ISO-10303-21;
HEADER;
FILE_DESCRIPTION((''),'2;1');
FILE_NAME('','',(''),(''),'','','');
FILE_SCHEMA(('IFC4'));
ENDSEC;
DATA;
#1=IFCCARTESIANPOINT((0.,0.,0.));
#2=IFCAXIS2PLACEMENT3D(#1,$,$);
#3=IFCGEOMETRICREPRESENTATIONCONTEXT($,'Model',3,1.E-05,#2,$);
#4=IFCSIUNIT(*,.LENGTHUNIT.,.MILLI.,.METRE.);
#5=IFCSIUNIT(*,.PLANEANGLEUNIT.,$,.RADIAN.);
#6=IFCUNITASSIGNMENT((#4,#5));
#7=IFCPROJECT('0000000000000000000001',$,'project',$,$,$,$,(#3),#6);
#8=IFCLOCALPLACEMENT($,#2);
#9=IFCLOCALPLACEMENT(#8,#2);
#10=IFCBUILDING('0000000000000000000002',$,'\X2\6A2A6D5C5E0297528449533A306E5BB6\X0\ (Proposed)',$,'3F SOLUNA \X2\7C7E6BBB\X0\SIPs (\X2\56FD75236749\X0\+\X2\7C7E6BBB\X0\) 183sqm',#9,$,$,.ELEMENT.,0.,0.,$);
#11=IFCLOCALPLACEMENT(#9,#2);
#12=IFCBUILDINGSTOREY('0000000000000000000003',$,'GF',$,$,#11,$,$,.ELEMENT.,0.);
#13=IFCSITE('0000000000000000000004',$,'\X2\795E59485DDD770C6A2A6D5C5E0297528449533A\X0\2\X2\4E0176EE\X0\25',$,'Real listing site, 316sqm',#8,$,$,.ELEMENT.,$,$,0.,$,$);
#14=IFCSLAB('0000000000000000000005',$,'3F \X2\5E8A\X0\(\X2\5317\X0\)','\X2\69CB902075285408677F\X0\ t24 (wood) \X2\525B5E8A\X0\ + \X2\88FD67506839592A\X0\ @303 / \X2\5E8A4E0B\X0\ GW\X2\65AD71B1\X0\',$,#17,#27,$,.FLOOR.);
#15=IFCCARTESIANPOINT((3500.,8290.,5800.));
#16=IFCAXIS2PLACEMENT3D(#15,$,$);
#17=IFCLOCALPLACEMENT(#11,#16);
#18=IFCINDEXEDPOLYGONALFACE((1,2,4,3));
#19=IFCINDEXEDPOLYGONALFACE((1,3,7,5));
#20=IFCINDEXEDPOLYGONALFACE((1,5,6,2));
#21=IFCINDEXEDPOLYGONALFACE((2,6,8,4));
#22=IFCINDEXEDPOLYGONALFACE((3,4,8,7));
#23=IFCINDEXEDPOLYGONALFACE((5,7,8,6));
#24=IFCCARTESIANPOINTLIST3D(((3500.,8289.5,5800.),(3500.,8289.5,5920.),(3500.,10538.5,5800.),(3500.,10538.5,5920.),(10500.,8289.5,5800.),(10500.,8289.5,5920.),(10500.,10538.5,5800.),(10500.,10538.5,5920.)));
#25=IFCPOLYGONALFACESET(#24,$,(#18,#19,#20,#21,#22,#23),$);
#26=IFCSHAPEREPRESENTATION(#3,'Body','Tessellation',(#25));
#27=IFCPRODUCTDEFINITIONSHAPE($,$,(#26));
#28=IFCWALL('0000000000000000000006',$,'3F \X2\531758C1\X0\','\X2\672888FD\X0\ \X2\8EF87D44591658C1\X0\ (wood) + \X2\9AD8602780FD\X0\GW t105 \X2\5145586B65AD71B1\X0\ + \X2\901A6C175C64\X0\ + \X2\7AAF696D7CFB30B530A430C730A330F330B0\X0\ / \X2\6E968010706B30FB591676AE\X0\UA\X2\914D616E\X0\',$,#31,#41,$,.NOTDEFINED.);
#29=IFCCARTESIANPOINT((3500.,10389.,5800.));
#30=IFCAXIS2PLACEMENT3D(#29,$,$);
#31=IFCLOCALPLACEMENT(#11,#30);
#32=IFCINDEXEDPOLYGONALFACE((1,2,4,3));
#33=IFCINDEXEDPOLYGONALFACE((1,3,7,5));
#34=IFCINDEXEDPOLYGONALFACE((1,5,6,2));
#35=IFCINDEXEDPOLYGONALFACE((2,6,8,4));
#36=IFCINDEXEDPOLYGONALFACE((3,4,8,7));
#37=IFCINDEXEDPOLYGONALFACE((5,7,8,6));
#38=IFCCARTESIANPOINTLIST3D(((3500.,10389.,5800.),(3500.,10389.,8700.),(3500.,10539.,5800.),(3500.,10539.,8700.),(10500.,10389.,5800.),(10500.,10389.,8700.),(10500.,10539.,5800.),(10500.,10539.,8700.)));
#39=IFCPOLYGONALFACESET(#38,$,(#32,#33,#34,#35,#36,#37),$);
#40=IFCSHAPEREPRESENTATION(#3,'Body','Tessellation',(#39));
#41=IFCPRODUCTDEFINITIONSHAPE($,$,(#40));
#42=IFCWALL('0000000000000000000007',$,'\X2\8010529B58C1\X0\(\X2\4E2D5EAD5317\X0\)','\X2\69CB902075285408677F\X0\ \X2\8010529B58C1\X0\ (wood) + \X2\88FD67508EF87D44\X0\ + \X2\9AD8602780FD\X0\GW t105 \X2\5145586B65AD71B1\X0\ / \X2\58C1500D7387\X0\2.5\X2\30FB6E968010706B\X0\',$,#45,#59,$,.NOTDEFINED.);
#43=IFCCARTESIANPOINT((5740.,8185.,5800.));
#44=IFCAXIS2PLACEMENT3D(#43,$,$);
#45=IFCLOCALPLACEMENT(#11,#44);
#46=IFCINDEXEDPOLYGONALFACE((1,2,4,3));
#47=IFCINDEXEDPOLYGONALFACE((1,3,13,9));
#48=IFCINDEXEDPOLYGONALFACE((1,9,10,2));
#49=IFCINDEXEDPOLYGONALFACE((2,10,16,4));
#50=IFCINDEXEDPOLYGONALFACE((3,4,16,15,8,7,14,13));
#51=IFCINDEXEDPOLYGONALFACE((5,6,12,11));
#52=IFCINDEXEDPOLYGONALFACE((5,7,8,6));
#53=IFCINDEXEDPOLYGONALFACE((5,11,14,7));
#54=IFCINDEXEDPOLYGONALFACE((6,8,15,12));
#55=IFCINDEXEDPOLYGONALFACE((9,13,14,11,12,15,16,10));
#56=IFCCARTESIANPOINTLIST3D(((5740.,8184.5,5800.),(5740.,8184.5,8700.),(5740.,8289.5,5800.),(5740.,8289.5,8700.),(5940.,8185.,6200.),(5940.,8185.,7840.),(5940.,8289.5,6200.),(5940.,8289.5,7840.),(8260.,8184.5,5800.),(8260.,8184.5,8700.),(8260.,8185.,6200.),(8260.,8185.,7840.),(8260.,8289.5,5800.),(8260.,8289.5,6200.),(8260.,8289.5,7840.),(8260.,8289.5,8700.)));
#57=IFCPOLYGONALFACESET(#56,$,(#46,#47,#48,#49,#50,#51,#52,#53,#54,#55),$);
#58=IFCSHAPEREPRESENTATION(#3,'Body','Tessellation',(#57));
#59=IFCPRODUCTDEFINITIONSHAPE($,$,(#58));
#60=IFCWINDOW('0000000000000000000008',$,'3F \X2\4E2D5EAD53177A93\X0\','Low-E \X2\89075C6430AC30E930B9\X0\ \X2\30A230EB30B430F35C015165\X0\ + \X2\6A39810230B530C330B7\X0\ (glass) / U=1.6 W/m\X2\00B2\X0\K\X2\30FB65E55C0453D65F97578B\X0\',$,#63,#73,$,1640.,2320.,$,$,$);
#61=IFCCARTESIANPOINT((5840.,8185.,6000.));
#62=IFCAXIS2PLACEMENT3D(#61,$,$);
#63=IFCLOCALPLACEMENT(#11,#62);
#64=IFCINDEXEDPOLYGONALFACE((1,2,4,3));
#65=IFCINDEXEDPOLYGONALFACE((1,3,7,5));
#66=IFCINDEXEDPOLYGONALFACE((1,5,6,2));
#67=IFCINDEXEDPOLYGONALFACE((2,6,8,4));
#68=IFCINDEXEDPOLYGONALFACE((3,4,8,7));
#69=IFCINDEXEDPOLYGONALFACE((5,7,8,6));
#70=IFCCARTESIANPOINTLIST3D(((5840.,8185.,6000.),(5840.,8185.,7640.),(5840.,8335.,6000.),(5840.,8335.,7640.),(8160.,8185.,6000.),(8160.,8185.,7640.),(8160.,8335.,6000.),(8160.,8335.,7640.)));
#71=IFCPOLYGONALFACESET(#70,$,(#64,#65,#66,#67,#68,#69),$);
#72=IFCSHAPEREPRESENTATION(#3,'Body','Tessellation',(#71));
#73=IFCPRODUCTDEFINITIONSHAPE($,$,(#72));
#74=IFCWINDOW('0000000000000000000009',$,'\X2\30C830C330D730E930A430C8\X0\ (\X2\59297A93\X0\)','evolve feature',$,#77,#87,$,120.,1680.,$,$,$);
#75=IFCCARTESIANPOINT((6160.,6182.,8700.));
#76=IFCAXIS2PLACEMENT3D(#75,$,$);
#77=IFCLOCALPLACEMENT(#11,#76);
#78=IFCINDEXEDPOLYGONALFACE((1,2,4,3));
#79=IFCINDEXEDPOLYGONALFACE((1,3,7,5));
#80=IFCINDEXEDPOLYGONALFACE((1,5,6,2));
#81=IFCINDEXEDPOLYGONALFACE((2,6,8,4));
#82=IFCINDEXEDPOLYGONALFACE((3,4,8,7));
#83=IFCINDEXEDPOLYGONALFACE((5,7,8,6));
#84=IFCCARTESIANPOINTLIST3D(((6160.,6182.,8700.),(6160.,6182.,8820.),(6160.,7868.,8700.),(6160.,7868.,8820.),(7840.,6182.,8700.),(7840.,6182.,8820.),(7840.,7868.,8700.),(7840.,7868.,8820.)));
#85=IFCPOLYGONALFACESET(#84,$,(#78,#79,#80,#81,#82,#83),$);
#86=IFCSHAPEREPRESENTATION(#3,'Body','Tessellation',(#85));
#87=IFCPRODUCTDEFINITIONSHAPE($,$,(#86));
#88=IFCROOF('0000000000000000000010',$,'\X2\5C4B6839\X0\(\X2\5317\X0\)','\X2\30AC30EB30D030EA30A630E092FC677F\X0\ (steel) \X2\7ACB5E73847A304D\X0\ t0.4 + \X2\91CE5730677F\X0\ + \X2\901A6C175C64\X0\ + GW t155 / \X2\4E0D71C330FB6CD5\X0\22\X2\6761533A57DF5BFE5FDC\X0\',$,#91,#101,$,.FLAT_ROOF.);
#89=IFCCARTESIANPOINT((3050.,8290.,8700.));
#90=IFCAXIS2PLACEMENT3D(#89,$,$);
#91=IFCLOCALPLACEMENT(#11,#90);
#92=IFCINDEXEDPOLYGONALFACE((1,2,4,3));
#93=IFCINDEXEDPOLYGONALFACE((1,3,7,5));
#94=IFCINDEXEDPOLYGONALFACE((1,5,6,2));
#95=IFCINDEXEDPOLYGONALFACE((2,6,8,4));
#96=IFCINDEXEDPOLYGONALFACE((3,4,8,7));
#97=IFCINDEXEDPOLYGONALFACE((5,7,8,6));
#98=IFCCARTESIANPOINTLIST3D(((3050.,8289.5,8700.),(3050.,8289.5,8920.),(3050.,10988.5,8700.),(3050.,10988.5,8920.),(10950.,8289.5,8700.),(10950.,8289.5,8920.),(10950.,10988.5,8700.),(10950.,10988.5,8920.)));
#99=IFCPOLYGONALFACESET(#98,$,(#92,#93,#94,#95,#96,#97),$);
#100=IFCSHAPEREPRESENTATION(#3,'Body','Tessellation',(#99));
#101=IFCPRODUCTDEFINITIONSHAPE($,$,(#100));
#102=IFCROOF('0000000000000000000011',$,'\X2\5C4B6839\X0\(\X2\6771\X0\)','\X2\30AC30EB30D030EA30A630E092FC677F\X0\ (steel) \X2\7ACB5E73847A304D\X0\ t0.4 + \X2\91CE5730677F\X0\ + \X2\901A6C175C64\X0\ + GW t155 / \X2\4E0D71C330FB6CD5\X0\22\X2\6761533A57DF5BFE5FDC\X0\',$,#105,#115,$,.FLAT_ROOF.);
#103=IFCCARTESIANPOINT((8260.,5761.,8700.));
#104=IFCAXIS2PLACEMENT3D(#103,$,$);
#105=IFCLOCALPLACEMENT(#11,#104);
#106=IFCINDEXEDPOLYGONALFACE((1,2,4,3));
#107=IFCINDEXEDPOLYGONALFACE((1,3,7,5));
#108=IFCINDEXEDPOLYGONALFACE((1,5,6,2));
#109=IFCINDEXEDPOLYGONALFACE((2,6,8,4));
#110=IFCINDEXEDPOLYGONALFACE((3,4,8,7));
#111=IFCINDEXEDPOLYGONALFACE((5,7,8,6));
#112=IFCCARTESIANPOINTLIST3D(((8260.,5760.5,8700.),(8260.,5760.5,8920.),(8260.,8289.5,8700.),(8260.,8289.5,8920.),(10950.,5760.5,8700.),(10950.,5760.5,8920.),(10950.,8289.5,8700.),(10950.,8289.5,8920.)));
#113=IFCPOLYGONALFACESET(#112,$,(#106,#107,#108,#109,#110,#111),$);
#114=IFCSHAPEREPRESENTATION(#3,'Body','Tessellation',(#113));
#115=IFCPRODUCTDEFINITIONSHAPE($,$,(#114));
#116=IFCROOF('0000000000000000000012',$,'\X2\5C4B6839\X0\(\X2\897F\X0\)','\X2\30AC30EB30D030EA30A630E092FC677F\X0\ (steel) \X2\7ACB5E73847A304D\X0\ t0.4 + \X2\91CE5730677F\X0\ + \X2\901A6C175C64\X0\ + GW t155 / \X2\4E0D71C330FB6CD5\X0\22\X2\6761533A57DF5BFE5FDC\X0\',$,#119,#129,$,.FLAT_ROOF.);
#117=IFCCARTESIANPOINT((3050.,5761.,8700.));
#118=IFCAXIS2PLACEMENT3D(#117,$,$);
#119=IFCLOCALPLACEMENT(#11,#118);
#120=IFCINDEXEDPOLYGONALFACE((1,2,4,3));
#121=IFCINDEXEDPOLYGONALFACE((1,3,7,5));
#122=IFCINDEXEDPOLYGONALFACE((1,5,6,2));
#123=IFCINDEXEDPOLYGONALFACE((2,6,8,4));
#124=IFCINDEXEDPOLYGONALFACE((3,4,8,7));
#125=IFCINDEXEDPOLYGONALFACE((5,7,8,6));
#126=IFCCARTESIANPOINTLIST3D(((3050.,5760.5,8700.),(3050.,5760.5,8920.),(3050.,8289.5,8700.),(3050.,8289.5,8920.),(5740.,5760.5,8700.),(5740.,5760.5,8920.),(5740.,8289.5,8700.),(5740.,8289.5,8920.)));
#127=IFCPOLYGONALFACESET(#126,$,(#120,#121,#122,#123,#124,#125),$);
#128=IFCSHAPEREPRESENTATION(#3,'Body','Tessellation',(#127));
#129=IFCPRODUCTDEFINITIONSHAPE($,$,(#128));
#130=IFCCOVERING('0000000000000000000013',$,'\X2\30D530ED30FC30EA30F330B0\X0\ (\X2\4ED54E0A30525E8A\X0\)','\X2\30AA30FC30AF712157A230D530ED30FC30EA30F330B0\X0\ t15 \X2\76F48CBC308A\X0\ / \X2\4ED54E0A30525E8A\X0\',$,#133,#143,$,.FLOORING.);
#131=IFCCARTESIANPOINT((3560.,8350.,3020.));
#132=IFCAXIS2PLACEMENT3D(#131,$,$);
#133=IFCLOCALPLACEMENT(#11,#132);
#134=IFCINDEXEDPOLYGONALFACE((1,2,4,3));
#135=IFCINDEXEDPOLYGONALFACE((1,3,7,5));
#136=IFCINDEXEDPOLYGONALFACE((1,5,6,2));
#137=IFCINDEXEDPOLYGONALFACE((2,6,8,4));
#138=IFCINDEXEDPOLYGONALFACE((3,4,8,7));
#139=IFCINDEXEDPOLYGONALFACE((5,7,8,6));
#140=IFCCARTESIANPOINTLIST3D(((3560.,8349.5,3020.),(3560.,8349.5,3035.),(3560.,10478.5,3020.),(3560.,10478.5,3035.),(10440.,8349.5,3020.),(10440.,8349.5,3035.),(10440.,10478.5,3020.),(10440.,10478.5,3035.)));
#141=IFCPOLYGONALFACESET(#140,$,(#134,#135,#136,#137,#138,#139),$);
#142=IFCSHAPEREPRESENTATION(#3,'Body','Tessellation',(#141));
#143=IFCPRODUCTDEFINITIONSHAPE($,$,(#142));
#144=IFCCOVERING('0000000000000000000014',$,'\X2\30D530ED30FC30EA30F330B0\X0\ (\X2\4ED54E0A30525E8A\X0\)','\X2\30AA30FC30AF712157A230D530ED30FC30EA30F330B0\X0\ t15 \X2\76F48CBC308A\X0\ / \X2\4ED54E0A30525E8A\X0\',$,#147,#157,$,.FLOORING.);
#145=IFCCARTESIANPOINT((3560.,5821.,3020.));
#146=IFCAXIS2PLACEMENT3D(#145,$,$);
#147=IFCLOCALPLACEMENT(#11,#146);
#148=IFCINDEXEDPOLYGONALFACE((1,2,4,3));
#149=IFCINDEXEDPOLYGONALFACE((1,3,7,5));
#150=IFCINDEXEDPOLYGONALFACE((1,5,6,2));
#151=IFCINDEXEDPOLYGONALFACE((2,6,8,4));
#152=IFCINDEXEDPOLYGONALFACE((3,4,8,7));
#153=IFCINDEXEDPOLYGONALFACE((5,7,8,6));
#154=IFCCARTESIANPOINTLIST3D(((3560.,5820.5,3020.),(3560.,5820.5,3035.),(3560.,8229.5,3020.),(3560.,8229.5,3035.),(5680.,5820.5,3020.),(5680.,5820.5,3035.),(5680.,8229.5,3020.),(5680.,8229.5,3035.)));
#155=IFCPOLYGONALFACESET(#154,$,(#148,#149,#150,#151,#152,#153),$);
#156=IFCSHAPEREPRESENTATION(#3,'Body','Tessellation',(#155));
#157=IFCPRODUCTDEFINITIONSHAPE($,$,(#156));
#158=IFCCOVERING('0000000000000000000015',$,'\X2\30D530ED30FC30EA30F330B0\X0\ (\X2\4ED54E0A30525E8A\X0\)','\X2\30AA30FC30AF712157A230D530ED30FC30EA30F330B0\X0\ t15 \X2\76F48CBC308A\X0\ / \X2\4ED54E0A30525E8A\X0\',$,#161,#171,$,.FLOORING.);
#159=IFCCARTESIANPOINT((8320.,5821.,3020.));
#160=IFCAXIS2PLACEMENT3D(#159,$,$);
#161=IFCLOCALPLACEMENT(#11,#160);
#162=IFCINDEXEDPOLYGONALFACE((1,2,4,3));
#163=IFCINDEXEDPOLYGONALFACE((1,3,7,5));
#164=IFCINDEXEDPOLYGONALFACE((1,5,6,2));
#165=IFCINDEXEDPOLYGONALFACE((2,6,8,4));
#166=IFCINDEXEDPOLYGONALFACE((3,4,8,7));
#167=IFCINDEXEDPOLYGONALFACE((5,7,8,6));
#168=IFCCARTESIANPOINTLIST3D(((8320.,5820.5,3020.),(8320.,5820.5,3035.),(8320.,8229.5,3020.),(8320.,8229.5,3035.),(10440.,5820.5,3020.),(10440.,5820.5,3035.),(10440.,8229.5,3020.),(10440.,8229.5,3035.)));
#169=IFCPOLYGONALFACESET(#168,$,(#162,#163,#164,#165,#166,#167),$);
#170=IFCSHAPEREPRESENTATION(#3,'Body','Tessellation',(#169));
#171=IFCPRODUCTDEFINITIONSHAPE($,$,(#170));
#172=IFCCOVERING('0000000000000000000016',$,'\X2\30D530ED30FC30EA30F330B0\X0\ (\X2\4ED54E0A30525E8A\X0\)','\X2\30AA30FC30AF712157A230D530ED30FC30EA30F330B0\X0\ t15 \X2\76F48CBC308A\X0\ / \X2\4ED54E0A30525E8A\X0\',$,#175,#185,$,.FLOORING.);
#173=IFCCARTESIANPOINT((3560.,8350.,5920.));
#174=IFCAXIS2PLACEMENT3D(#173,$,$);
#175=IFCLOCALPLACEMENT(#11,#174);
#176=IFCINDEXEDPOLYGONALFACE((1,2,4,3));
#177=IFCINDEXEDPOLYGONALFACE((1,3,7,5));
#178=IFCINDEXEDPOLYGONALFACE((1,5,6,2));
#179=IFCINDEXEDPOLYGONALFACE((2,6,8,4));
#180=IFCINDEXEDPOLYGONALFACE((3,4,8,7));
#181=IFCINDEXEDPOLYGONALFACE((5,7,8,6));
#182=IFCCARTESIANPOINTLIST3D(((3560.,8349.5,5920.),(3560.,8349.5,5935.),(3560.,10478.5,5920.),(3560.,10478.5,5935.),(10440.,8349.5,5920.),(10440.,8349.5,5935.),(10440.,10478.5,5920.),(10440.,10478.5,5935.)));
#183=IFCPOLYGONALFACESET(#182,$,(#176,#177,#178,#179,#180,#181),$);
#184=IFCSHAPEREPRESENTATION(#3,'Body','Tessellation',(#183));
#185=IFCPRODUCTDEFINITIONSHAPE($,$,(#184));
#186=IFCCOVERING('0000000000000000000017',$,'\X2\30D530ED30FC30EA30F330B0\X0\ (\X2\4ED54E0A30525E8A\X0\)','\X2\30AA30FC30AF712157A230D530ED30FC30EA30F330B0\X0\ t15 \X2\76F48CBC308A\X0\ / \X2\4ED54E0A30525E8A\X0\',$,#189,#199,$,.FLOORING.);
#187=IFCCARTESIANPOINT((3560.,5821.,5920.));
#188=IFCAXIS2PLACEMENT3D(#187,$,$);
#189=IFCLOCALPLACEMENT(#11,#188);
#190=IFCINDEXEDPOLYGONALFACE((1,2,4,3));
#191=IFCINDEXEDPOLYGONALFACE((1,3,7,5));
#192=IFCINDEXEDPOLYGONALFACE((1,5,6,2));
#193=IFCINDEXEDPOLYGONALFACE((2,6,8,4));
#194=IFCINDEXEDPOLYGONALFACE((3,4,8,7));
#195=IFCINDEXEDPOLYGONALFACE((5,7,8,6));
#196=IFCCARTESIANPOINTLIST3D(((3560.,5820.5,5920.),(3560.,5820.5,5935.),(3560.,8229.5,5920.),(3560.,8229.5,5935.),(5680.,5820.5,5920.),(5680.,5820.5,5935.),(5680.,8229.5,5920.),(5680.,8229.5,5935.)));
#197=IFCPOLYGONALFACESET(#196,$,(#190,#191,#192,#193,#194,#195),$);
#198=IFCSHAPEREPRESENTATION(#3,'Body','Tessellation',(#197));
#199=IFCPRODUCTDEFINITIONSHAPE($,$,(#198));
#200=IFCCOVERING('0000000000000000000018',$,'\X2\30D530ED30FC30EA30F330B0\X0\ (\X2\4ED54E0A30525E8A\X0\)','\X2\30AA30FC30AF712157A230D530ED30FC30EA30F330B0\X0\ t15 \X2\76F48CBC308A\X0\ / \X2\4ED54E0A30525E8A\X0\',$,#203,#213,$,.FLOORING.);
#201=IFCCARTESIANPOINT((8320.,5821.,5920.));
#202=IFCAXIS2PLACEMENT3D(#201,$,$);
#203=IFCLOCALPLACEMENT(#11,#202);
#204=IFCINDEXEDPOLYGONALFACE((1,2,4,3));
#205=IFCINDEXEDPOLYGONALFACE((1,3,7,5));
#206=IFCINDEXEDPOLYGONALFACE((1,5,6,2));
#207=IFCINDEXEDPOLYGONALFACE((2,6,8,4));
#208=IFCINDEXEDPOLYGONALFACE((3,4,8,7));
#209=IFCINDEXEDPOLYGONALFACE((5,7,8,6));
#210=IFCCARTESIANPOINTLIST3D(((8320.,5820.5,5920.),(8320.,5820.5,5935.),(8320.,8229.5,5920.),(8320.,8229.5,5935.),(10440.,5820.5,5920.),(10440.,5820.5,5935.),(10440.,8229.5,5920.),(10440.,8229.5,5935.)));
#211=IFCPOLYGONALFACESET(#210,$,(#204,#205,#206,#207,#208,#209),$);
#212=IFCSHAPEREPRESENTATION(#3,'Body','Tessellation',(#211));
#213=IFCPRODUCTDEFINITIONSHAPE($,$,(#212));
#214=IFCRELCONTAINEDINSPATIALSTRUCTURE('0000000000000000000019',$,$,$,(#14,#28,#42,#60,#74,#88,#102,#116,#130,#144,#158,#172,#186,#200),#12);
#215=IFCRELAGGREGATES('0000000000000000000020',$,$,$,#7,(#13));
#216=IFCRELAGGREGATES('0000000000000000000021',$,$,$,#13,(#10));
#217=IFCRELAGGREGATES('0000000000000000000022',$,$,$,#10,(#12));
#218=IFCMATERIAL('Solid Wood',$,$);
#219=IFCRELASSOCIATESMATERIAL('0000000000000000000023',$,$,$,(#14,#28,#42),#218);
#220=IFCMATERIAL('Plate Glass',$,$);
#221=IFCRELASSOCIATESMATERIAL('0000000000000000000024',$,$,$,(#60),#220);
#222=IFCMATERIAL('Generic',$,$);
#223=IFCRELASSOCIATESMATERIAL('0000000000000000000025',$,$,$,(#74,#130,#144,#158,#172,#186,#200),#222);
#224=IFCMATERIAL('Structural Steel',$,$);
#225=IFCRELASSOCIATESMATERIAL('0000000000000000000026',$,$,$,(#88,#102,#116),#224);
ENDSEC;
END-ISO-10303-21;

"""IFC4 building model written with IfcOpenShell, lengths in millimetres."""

from ifc_helpers import new_model, si_unit, frame, frame_2d, origin, place, context, project, spatial, rectangle, extrude, material, element, fill, save


model = new_model("IFC4")

# Units and contexts
model_context = context("Model", 3, precision=1e-05, world=origin())
ifc_project = project(units=[si_unit("LENGTHUNIT", "METRE", prefix="MILLI"), si_unit("PLANEANGLEUNIT", "RADIAN")], contexts=[model_context])

# Site, building, storey
site_placement = place(None, origin())
site = spatial("IfcSite", under=ifc_project, at=site_placement, Name="神奈川県横浜市青葉区2丁目25", ObjectType="Real listing site, 316sqm", CompositionType="ELEMENT", RefElevation=0.0)
building_placement = place(site_placement, origin())
building = spatial("IfcBuilding", under=site, at=building_placement, Name="横浜市青葉区の家 (Proposed)", ObjectType="3F SOLUNA 籾殻SIPs (国産杉+籾殻) 183sqm", CompositionType="ELEMENT", ElevationOfRefHeight=0.0, ElevationOfTerrain=0.0)
storey_placement = place(building_placement, origin())
storey = spatial("IfcBuildingStorey", under=building, at=storey_placement, Name="GF", CompositionType="ELEMENT", Elevation=0.0)

# Slab
ifc_material_1 = material(Name="Solid Wood")
slab_placement = place(storey_placement, frame((3500.0, 8290.0, 5800.0)))
element("IfcSlab", 1, at=slab_placement, inside=storey, material=ifc_material_1, Name="3F 床(北)", Description="構造用合板 t24 (wood) 剛床 + 製材根太 @303 / 床下 GW断熱", PredefinedType="FLOOR", context=model_context, shape_type="SweptSolid", body=[
    extrude(rectangle(XDim=7000.0, YDim=2249.0, at=frame_2d((3500.0, 1124.0))), frame((3500.0, 8290.0, 5800.0)), (0.0, 0.0, 1.0), 120.0),
])

# Wall
wall_1_placement = place(storey_placement, frame((3500.0, 10389.0, 5800.0)))
element("IfcWall", 2, at=wall_1_placement, inside=storey, material=ifc_material_1, Name="3F 北壁", Description="木製 軸組外壁 (wood) + 高性能GW t105 充填断熱 + 通気層 + 窯業系サイディング / 準耐火・外皮UA配慮", PredefinedType="NOTDEFINED", context=model_context, shape_type="SweptSolid", body=[
    extrude(rectangle(XDim=7000.0, YDim=150.0, at=frame_2d((3500.0, 75.0))), frame((3500.0, 10389.0, 5800.0)), (0.0, 0.0, 1.0), 2900.0),
])

# Wall, opening, window
wall_2_placement = place(storey_placement, frame((5740.0, 8185.0, 5800.0)))
wall_2 = element("IfcWall", 3, at=wall_2_placement, inside=storey, material=ifc_material_1, Name="耐力壁(中庭北)", Description="構造用合板 耐力壁 (wood) + 製材軸組 + 高性能GW t105 充填断熱 / 壁倍率2.5・準耐火", PredefinedType="NOTDEFINED", context=model_context, shape_type="SweptSolid", body=[
    extrude(rectangle(XDim=2520.0, YDim=105.0, at=frame_2d((1260.0, 52.0))), frame((5740.0, 8185.0, 5800.0)), (0.0, 0.0, 1.0), 2900.0),
])
opening_placement = place(storey_placement, frame((5840.0, 8185.0, 6000.0)))
opening = element("IfcOpeningElement", 4, at=opening_placement, cuts=wall_2, PredefinedType="NOTDEFINED", context=model_context, shape_type="SweptSolid", body=[
    extrude(rectangle(XDim=2320.0, YDim=150.0, at=frame_2d((1160.0, 75.0))), frame((5840.0, 8185.0, 6000.0)), (0.0, 0.0, 1.0), 1640.0),
])
ifc_material_2 = material(Name="Plate Glass")
window_1_placement = place(storey_placement, frame((5840.0, 8185.0, 6000.0)))
window_1 = element("IfcWindow", 5, at=window_1_placement, inside=storey, material=ifc_material_2, Name="3F 中庭北窓", Description="Low-E 複層ガラス アルゴン封入 + 樹脂サッシ (glass) / U=1.6 W/m²K・日射取得型", OverallHeight=1640.0, OverallWidth=2320.0, context=model_context, shape_type="SweptSolid", body=[
    extrude(rectangle(XDim=2320.0, YDim=150.0, at=frame_2d((1160.0, 75.0))), frame((5840.0, 8185.0, 6000.0)), (0.0, 0.0, 1.0), 1640.0),
])
fill(opening, window_1)

# Window
ifc_material_3 = material(Name="Generic")
window_2_placement = place(storey_placement, frame((6160.0, 6182.0, 8700.0)))
element("IfcWindow", 6, at=window_2_placement, inside=storey, material=ifc_material_3, Name="トップライト (天窓)", Description="evolve feature", OverallHeight=120.0, OverallWidth=1680.0, context=model_context, shape_type="SweptSolid", body=[
    extrude(rectangle(XDim=1680.0, YDim=1686.0, at=frame_2d((840.0, 843.0))), frame((6160.0, 6182.0, 8700.0)), (0.0, 0.0, 1.0), 120.0),
])

# Roofs
ifc_material_4 = material(Name="Structural Steel")
roof_1_placement = place(storey_placement, frame((3050.0, 8290.0, 8700.0)))
element("IfcRoof", 7, at=roof_1_placement, inside=storey, material=ifc_material_4, Name="屋根(北)", Description="ガルバリウム鋼板 (steel) 立平葺き t0.4 + 野地板 + 通気層 + GW t155 / 不燃・法22条区域対応", PredefinedType="FLAT_ROOF", context=model_context, shape_type="SweptSolid", body=[
    extrude(rectangle(XDim=7900.0, YDim=2699.0, at=frame_2d((3950.0, 1349.0))), frame((3050.0, 8290.0, 8700.0)), (0.0, 0.0, 1.0), 220.0),
])
roof_2_placement = place(storey_placement, frame((8260.0, 5761.0, 8700.0)))
element("IfcRoof", 8, at=roof_2_placement, inside=storey, material=ifc_material_4, Name="屋根(東)", Description="ガルバリウム鋼板 (steel) 立平葺き t0.4 + 野地板 + 通気層 + GW t155 / 不燃・法22条区域対応", PredefinedType="FLAT_ROOF", context=model_context, shape_type="SweptSolid", body=[
    extrude(rectangle(XDim=2690.0, YDim=2529.0, at=frame_2d((1345.0, 1264.0))), frame((8260.0, 5761.0, 8700.0)), (0.0, 0.0, 1.0), 220.0),
])
roof_3_placement = place(storey_placement, frame((3050.0, 5761.0, 8700.0)))
element("IfcRoof", 9, at=roof_3_placement, inside=storey, material=ifc_material_4, Name="屋根(西)", Description="ガルバリウム鋼板 (steel) 立平葺き t0.4 + 野地板 + 通気層 + GW t155 / 不燃・法22条区域対応", PredefinedType="FLAT_ROOF", context=model_context, shape_type="SweptSolid", body=[
    extrude(rectangle(XDim=2690.0, YDim=2529.0, at=frame_2d((1345.0, 1264.0))), frame((3050.0, 5761.0, 8700.0)), (0.0, 0.0, 1.0), 220.0),
])

# Coverings
covering_1_placement = place(storey_placement, frame((3560.0, 8350.0, 3020.0)))
element("IfcCovering", 10, at=covering_1_placement, inside=storey, material=ifc_material_3, Name="フローリング (仕上げ床)", Description="オーク無垢フローリング t15 直貼り / 仕上げ床", PredefinedType="FLOORING", context=model_context, shape_type="SweptSolid", body=[
    extrude(rectangle(XDim=6880.0, YDim=2129.0, at=frame_2d((3440.0, 1064.0))), frame((3560.0, 8350.0, 3020.0)), (0.0, 0.0, 1.0), 15.0),
])
covering_2_placement = place(storey_placement, frame((3560.0, 5821.0, 3020.0)))
element("IfcCovering", 11, at=covering_2_placement, inside=storey, material=ifc_material_3, Name="フローリング (仕上げ床)", Description="オーク無垢フローリング t15 直貼り / 仕上げ床", PredefinedType="FLOORING", context=model_context, shape_type="SweptSolid", body=[
    extrude(rectangle(XDim=2120.0, YDim=2409.0, at=frame_2d((1060.0, 1204.0))), frame((3560.0, 5821.0, 3020.0)), (0.0, 0.0, 1.0), 15.0),
])
covering_3_placement = place(storey_placement, frame((8320.0, 5821.0, 3020.0)))
element("IfcCovering", 12, at=covering_3_placement, inside=storey, material=ifc_material_3, Name="フローリング (仕上げ床)", Description="オーク無垢フローリング t15 直貼り / 仕上げ床", PredefinedType="FLOORING", context=model_context, shape_type="SweptSolid", body=[
    extrude(rectangle(XDim=2120.0, YDim=2409.0, at=frame_2d((1060.0, 1204.0))), frame((8320.0, 5821.0, 3020.0)), (0.0, 0.0, 1.0), 15.0),
])
covering_4_placement = place(storey_placement, frame((3560.0, 8350.0, 5920.0)))
element("IfcCovering", 13, at=covering_4_placement, inside=storey, material=ifc_material_3, Name="フローリング (仕上げ床)", Description="オーク無垢フローリング t15 直貼り / 仕上げ床", PredefinedType="FLOORING", context=model_context, shape_type="SweptSolid", body=[
    extrude(rectangle(XDim=6880.0, YDim=2129.0, at=frame_2d((3440.0, 1064.0))), frame((3560.0, 8350.0, 5920.0)), (0.0, 0.0, 1.0), 15.0),
])
covering_5_placement = place(storey_placement, frame((3560.0, 5821.0, 5920.0)))
element("IfcCovering", 14, at=covering_5_placement, inside=storey, material=ifc_material_3, Name="フローリング (仕上げ床)", Description="オーク無垢フローリング t15 直貼り / 仕上げ床", PredefinedType="FLOORING", context=model_context, shape_type="SweptSolid", body=[
    extrude(rectangle(XDim=2120.0, YDim=2409.0, at=frame_2d((1060.0, 1204.0))), frame((3560.0, 5821.0, 5920.0)), (0.0, 0.0, 1.0), 15.0),
])
covering_6_placement = place(storey_placement, frame((8320.0, 5821.0, 5920.0)))
element("IfcCovering", 15, at=covering_6_placement, inside=storey, material=ifc_material_3, Name="フローリング (仕上げ床)", Description="オーク無垢フローリング t15 直貼り / 仕上げ床", PredefinedType="FLOORING", context=model_context, shape_type="SweptSolid", body=[
    extrude(rectangle(XDim=2120.0, YDim=2409.0, at=frame_2d((1060.0, 1204.0))), frame((8320.0, 5821.0, 5920.0)), (0.0, 0.0, 1.0), 15.0),
])

save(model, "model.ifc")
